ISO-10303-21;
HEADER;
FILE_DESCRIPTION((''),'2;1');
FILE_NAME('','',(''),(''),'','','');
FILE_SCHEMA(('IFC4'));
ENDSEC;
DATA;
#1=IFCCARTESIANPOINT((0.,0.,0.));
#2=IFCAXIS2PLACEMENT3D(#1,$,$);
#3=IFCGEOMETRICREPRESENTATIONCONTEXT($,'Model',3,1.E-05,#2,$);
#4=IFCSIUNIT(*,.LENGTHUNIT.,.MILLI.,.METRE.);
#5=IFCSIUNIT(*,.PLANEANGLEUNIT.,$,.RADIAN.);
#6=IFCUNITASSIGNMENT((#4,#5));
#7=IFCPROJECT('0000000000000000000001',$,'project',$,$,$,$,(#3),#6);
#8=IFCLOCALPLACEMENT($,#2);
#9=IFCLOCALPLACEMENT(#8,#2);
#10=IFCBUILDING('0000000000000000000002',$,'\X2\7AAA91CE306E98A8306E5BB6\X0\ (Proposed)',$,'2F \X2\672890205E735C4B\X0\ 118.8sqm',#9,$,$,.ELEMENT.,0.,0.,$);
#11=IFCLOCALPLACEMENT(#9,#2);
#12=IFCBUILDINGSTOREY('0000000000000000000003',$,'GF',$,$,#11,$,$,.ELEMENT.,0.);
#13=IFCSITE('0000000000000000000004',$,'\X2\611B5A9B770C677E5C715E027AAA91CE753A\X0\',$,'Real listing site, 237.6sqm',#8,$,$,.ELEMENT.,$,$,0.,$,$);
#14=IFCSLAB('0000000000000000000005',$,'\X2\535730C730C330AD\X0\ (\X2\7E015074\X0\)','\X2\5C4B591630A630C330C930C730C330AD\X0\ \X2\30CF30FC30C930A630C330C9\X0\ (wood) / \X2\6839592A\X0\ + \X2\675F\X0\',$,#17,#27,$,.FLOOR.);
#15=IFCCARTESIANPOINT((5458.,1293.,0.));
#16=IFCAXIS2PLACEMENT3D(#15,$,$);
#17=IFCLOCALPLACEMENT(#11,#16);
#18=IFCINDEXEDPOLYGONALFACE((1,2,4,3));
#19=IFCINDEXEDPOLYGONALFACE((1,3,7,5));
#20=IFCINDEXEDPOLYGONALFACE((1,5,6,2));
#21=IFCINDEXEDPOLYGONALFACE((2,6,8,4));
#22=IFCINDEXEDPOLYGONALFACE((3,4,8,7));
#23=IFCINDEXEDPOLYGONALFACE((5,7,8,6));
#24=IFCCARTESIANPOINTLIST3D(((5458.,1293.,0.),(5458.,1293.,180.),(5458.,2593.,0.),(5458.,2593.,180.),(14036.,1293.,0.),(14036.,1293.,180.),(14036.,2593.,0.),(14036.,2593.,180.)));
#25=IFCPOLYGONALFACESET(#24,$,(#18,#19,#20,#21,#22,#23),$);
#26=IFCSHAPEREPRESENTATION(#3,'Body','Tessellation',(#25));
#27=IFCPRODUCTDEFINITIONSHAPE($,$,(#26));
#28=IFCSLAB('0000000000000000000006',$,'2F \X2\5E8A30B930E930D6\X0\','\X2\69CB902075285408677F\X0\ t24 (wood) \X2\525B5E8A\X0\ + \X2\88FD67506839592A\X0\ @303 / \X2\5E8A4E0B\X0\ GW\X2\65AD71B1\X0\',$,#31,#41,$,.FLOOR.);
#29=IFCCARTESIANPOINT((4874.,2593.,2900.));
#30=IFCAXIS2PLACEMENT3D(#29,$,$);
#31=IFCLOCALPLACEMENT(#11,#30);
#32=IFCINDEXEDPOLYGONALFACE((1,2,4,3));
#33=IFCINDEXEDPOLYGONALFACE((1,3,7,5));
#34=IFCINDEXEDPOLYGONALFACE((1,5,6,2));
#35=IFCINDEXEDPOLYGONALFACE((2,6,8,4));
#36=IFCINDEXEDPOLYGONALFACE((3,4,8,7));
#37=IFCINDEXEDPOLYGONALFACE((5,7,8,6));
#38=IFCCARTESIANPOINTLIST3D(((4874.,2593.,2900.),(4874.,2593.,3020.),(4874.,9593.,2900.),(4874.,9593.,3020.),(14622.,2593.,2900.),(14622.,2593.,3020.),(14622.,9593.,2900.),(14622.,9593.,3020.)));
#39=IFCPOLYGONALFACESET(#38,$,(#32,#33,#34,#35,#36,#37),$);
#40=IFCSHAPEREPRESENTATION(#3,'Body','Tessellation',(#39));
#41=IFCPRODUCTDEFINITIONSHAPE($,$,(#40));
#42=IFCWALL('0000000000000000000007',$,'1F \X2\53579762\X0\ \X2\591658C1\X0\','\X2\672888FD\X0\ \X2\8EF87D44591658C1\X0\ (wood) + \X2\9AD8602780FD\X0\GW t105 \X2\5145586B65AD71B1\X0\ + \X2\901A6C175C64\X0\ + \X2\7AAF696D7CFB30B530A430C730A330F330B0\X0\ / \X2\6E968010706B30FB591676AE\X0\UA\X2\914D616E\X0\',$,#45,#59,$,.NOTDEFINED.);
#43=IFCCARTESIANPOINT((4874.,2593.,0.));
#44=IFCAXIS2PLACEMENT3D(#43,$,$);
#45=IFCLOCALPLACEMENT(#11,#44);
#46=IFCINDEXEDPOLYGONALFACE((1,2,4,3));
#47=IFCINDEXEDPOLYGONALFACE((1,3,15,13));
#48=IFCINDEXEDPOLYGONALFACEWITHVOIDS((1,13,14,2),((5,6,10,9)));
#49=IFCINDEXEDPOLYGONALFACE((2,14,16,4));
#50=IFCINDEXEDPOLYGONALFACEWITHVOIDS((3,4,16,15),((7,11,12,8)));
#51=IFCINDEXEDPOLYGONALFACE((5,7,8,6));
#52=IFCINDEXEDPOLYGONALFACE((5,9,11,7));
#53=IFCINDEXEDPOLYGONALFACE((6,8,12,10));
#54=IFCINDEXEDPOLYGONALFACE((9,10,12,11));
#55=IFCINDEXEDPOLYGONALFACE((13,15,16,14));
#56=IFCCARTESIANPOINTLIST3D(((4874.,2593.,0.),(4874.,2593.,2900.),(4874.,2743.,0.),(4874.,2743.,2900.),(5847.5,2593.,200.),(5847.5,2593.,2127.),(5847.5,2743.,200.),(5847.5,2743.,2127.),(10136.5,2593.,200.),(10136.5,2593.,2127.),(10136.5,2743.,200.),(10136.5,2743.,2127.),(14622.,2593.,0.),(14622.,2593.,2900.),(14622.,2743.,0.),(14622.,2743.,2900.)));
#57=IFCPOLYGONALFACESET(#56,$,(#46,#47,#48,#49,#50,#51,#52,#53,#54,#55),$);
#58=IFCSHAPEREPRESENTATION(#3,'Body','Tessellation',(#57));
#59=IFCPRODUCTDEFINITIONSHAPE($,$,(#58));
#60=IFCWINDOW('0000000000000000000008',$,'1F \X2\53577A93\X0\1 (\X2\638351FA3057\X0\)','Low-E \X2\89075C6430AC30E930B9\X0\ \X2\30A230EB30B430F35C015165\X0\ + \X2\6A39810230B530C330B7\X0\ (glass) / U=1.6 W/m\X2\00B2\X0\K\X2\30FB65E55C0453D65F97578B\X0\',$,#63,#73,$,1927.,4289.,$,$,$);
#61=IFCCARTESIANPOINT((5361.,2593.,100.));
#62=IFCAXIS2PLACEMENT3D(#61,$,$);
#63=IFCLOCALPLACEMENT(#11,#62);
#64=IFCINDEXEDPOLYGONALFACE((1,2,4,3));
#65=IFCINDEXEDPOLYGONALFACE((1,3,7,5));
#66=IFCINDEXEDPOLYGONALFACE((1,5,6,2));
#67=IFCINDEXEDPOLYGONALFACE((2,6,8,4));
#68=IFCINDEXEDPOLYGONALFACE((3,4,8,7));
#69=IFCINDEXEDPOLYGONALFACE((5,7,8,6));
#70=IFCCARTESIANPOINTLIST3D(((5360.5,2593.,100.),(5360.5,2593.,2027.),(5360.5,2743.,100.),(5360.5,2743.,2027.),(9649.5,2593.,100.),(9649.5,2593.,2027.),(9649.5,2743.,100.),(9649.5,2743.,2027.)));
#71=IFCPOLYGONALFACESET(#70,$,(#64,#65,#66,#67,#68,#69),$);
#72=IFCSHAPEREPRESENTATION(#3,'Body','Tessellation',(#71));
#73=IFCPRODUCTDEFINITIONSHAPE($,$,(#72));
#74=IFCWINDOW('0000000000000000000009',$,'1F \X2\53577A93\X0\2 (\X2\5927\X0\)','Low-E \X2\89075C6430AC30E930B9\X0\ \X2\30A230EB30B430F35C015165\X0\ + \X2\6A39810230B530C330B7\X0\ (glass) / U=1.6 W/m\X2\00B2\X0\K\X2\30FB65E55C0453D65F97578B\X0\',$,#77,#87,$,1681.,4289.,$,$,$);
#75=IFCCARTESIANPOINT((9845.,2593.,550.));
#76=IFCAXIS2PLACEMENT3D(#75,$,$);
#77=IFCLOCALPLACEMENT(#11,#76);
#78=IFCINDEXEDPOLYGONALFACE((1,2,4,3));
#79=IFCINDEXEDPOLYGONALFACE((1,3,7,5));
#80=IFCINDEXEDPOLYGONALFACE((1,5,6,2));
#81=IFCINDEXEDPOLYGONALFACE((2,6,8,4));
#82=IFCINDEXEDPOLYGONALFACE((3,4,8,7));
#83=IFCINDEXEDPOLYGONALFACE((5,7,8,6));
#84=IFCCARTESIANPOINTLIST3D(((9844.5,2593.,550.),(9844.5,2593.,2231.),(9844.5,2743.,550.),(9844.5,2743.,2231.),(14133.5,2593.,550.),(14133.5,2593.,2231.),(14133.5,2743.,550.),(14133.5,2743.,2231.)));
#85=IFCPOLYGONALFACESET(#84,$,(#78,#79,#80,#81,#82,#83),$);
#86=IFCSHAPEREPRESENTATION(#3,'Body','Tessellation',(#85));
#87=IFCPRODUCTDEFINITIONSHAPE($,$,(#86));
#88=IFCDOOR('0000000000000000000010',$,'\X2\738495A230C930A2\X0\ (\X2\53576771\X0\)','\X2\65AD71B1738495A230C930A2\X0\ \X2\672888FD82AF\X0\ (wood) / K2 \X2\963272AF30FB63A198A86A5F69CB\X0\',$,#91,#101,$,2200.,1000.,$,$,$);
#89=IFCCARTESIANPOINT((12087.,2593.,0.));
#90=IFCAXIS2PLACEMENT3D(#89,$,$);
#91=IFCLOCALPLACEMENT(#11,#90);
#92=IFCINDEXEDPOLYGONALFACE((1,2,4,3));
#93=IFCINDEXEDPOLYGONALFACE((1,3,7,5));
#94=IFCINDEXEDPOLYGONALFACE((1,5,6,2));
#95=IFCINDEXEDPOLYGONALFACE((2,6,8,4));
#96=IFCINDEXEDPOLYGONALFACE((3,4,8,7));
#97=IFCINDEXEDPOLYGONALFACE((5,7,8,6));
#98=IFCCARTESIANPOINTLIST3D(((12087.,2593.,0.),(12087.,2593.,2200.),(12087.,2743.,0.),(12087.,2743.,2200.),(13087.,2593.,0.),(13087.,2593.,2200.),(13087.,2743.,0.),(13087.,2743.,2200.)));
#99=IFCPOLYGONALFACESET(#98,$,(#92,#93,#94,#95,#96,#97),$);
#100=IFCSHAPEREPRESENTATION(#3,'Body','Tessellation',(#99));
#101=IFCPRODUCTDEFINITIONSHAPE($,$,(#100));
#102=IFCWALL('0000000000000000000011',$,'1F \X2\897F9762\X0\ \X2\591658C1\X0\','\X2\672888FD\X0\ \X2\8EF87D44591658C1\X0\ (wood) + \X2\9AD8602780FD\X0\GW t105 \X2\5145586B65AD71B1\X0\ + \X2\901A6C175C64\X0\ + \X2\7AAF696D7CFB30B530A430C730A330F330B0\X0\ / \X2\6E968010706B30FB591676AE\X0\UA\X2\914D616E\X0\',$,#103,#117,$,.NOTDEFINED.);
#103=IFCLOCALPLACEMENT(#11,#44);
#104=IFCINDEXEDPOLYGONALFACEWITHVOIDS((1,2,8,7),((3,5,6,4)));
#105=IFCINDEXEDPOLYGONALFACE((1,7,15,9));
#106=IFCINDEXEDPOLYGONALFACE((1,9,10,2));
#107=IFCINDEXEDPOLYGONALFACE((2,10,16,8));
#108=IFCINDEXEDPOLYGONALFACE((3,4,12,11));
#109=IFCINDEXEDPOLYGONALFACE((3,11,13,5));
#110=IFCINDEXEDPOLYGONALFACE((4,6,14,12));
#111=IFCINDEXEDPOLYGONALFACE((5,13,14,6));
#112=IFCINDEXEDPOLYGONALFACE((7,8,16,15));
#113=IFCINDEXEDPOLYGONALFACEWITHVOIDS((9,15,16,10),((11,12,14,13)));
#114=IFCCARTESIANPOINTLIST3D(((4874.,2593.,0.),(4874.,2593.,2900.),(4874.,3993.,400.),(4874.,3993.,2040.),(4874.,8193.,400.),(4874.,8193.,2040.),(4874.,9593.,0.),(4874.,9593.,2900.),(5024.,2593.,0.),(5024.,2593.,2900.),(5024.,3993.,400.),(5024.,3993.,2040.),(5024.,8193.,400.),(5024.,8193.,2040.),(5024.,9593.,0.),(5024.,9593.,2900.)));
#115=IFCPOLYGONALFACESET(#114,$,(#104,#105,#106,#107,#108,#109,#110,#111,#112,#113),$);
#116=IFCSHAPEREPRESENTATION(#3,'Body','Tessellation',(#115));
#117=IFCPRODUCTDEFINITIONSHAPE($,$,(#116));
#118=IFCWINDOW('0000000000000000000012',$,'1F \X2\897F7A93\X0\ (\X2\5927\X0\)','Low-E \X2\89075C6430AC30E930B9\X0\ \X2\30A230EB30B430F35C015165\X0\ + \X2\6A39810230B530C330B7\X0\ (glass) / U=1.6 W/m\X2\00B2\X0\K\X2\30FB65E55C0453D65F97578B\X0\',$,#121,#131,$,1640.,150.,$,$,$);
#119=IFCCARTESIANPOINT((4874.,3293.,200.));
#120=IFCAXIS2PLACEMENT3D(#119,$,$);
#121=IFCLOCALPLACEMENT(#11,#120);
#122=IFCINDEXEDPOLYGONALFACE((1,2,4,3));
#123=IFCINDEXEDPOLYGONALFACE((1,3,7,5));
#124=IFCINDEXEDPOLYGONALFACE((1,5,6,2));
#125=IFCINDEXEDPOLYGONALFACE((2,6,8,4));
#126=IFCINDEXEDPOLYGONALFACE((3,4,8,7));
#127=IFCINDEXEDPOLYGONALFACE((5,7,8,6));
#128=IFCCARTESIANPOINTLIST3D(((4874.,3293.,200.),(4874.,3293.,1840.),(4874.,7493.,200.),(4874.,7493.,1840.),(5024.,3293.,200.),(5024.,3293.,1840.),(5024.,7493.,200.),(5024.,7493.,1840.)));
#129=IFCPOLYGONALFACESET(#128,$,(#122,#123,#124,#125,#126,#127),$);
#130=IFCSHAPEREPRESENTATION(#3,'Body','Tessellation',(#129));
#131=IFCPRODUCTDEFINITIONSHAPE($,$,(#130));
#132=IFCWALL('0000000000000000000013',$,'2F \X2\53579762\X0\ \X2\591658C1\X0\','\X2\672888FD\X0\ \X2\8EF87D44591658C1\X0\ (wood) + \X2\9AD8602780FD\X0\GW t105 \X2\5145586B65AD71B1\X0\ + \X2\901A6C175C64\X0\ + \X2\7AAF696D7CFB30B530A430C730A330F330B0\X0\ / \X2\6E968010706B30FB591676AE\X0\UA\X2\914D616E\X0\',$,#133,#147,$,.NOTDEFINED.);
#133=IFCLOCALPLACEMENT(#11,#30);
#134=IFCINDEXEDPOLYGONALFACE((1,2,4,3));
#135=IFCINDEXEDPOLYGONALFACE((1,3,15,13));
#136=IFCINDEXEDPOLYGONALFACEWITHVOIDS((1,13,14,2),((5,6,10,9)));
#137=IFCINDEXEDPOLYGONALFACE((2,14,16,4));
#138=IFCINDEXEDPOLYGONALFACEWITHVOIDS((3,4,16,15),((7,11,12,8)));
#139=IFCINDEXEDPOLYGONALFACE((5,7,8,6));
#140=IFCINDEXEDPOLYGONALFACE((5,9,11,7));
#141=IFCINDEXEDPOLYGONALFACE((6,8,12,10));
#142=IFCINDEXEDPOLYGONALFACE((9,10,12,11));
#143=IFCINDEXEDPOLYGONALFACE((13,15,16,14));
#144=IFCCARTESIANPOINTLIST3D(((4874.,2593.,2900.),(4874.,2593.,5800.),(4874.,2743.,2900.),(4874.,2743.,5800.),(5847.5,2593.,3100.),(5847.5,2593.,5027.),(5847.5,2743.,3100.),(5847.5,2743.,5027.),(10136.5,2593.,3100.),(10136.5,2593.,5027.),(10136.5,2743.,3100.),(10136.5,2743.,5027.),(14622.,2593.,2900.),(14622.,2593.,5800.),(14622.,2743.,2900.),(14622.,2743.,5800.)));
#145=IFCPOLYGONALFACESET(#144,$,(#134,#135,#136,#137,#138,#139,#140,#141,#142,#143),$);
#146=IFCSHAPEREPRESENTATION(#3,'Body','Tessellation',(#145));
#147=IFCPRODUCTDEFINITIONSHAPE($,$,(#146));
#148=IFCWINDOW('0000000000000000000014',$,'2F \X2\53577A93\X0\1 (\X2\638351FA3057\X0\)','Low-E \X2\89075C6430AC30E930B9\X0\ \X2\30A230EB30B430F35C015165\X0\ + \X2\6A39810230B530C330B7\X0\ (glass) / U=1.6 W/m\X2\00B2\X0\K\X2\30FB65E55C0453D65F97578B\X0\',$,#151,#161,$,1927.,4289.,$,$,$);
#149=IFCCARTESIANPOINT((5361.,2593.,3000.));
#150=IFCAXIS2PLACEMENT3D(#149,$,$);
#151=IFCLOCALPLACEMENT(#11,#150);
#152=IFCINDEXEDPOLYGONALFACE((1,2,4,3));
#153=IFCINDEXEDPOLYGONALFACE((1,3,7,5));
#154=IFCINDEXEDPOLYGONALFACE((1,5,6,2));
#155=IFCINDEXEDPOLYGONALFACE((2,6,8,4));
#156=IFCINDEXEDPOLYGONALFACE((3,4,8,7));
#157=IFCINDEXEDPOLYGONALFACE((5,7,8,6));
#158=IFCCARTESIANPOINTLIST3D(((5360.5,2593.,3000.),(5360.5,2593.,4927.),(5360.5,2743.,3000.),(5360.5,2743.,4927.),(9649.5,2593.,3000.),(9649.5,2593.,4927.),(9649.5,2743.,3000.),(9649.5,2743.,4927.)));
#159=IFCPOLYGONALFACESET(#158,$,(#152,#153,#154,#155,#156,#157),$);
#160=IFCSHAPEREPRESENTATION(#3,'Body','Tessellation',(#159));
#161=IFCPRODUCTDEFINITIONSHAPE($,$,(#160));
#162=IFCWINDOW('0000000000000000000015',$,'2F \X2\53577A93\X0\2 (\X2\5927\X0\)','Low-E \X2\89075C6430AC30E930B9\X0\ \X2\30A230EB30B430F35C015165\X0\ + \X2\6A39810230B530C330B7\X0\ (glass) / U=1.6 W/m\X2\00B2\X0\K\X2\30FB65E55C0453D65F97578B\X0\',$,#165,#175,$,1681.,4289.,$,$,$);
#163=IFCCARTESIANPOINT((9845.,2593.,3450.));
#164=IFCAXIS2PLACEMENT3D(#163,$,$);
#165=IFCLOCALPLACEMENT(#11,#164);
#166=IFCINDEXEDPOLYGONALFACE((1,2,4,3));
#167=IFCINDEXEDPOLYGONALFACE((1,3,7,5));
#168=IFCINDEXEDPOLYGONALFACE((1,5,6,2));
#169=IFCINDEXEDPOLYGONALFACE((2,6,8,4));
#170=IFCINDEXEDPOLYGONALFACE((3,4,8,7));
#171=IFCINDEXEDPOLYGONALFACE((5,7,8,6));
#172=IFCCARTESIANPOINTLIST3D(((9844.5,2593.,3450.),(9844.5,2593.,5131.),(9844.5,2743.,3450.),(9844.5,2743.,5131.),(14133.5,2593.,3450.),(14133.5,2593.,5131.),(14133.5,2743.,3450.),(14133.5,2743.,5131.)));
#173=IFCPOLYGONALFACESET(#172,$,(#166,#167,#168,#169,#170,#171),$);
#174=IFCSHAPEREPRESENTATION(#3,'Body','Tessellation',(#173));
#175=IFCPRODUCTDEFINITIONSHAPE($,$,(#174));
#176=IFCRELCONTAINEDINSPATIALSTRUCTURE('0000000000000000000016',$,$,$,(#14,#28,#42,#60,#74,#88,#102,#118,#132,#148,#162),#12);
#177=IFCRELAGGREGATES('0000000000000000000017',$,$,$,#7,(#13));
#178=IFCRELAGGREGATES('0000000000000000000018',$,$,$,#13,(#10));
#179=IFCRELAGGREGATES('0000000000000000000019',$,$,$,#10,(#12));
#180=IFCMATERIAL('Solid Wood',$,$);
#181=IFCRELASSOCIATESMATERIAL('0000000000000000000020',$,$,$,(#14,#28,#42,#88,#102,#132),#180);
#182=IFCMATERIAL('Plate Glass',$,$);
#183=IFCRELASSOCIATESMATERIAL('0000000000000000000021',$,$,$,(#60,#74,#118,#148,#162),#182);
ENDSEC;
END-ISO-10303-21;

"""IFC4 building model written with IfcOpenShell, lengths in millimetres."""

from ifc_helpers import new_model, si_unit, frame, frame_2d, origin, place, context, project, spatial, rectangle, extrude, material, element, fill, save


model = new_model("IFC4")

# Units and contexts
model_context = context("Model", 3, precision=1e-05, world=origin())
ifc_project = project(units=[si_unit("LENGTHUNIT", "METRE", prefix="MILLI"), si_unit("PLANEANGLEUNIT", "RADIAN")], contexts=[model_context])

# Site, building, storey
site_placement = place(None, origin())
site = spatial("IfcSite", under=ifc_project, at=site_placement, Name="愛媛県松山市窪野町", ObjectType="Real listing site, 237.6sqm", CompositionType="ELEMENT", RefElevation=0.0)
building_placement = place(site_placement, origin())
building = spatial("IfcBuilding", under=site, at=building_placement, Name="窪野の風の家 (Proposed)", ObjectType="2F 木造平屋 118.8sqm", CompositionType="ELEMENT", ElevationOfRefHeight=0.0, ElevationOfTerrain=0.0)
storey_placement = place(building_placement, origin())
storey = spatial("IfcBuildingStorey", under=building, at=storey_placement, Name="GF", CompositionType="ELEMENT", Elevation=0.0)

# Slabs
ifc_material_1 = material(Name="Solid Wood")
slab_1_placement = place(storey_placement, frame((5458.0, 1293.0, 0.0)))
element("IfcSlab", 1, at=slab_1_placement, inside=storey, material=ifc_material_1, Name="南デッキ (縁側)", Description="屋外ウッドデッキ ハードウッド (wood) / 根太 + 束", PredefinedType="FLOOR", context=model_context, shape_type="SweptSolid", body=[
    extrude(rectangle(XDim=8578.0, YDim=1300.0, at=frame_2d((4289.0, 650.0))), frame((5458.0, 1293.0, 0.0)), (0.0, 0.0, 1.0), 180.0),
])
slab_2_placement = place(storey_placement, frame((4874.0, 2593.0, 2900.0)))
element("IfcSlab", 2, at=slab_2_placement, inside=storey, material=ifc_material_1, Name="2F 床スラブ", Description="構造用合板 t24 (wood) 剛床 + 製材根太 @303 / 床下 GW断熱", PredefinedType="FLOOR", context=model_context, shape_type="SweptSolid", body=[
    extrude(rectangle(XDim=9748.0, YDim=7000.0, at=frame_2d((4874.0, 3500.0))), frame((4874.0, 2593.0, 2900.0)), (0.0, 0.0, 1.0), 120.0),
])

# Wall, openings, windows, door
wall_1_placement = place(storey_placement, frame((4874.0, 2593.0, 0.0)))
wall_1 = element("IfcWall", 3, at=wall_1_placement, inside=storey, material=ifc_material_1, Name="1F 南面 外壁", Description="木製 軸組外壁 (wood) + 高性能GW t105 充填断熱 + 通気層 + 窯業系サイディング / 準耐火・外皮UA配慮", PredefinedType="NOTDEFINED", context=model_context, shape_type="SweptSolid", body=[
    extrude(rectangle(XDim=9748.0, YDim=150.0, at=frame_2d((4874.0, 75.0))), frame((4874.0, 2593.0, 0.0)), (0.0, 0.0, 1.0), 2900.0),
])
opening_1_placement = place(storey_placement, frame((5361.0, 2593.0, 100.0)))
opening_1 = element("IfcOpeningElement", 4, at=opening_1_placement, cuts=wall_1, PredefinedType="NOTDEFINED", context=model_context, shape_type="SweptSolid", body=[
    extrude(rectangle(XDim=4289.0, YDim=150.0, at=frame_2d((2144.0, 75.0))), frame((5361.0, 2593.0, 100.0)), (0.0, 0.0, 1.0), 1927.0),
])
opening_2_placement = place(storey_placement, frame((9845.0, 2593.0, 550.0)))
opening_2 = element("IfcOpeningElement", 5, at=opening_2_placement, cuts=wall_1, PredefinedType="NOTDEFINED", context=model_context, shape_type="SweptSolid", body=[
    extrude(rectangle(XDim=4289.0, YDim=150.0, at=frame_2d((2144.0, 75.0))), frame((9845.0, 2593.0, 550.0)), (0.0, 0.0, 1.0), 1681.0),
])
opening_3_placement = place(storey_placement, frame((12087.0, 2593.0, 0.0)))
opening_3 = element("IfcOpeningElement", 6, at=opening_3_placement, cuts=wall_1, PredefinedType="NOTDEFINED", context=model_context, shape_type="SweptSolid", body=[
    extrude(rectangle(XDim=1000.0, YDim=150.0, at=frame_2d((500.0, 75.0))), frame((12087.0, 2593.0, 0.0)), (0.0, 0.0, 1.0), 2200.0),
])
ifc_material_2 = material(Name="Plate Glass")
window_1_placement = place(storey_placement, frame((5361.0, 2593.0, 100.0)))
window_1 = element("IfcWindow", 7, at=window_1_placement, inside=storey, material=ifc_material_2, Name="1F 南窓1 (掃出し)", Description="Low-E 複層ガラス アルゴン封入 + 樹脂サッシ (glass) / U=1.6 W/m²K・日射取得型", OverallHeight=1927.0, OverallWidth=4289.0, context=model_context, shape_type="SweptSolid", body=[
    extrude(rectangle(XDim=4289.0, YDim=150.0, at=frame_2d((2144.0, 75.0))), frame((5361.0, 2593.0, 100.0)), (0.0, 0.0, 1.0), 1927.0),
])
fill(opening_1, window_1)
window_2_placement = place(storey_placement, frame((9845.0, 2593.0, 550.0)))
window_2 = element("IfcWindow", 8, at=window_2_placement, inside=storey, material=ifc_material_2, Name="1F 南窓2 (大)", Description="Low-E 複層ガラス アルゴン封入 + 樹脂サッシ (glass) / U=1.6 W/m²K・日射取得型", OverallHeight=1681.0, OverallWidth=4289.0, context=model_context, shape_type="SweptSolid", body=[
    extrude(rectangle(XDim=4289.0, YDim=150.0, at=frame_2d((2144.0, 75.0))), frame((9845.0, 2593.0, 550.0)), (0.0, 0.0, 1.0), 1681.0),
])
fill(opening_2, window_2)
door_placement = place(storey_placement, frame((12087.0, 2593.0, 0.0)))
door = element("IfcDoor", 9, at=door_placement, inside=storey, material=ifc_material_1, Name="玄関ドア (南東)", Description="断熱玄関ドア 木製芯 (wood) / K2 防犯・採風機構", OverallHeight=2200.0, OverallWidth=1000.0, context=model_context, shape_type="SweptSolid", body=[
    extrude(rectangle(XDim=1000.0, YDim=150.0, at=frame_2d((500.0, 75.0))), frame((12087.0, 2593.0, 0.0)), (0.0, 0.0, 1.0), 2200.0),
])
fill(opening_3, door)

# Wall, opening, window
wall_2_placement = place(storey_placement, frame((4874.0, 2593.0, 0.0)))
wall_2 = element("IfcWall", 10, at=wall_2_placement, inside=storey, material=ifc_material_1, Name="1F 西面 外壁", Description="木製 軸組外壁 (wood) + 高性能GW t105 充填断熱 + 通気層 + 窯業系サイディング / 準耐火・外皮UA配慮", PredefinedType="NOTDEFINED", context=model_context, shape_type="SweptSolid", body=[
    extrude(rectangle(XDim=150.0, YDim=7000.0, at=frame_2d((75.0, 3500.0))), frame((4874.0, 2593.0, 0.0)), (0.0, 0.0, 1.0), 2900.0),
])
opening_4_placement = place(storey_placement, frame((4874.0, 3293.0, 200.0)))
opening_4 = element("IfcOpeningElement", 11, at=opening_4_placement, cuts=wall_2, PredefinedType="NOTDEFINED", context=model_context, shape_type="SweptSolid", body=[
    extrude(rectangle(XDim=150.0, YDim=4200.0, at=frame_2d((75.0, 2100.0))), frame((4874.0, 3293.0, 200.0)), (0.0, 0.0, 1.0), 1640.0),
])
window_3_placement = place(storey_placement, frame((4874.0, 3293.0, 200.0)))
window_3 = element("IfcWindow", 12, at=window_3_placement, inside=storey, material=ifc_material_2, Name="1F 西窓 (大)", Description="Low-E 複層ガラス アルゴン封入 + 樹脂サッシ (glass) / U=1.6 W/m²K・日射取得型", OverallHeight=1640.0, OverallWidth=150.0, context=model_context, shape_type="SweptSolid", body=[
    extrude(rectangle(XDim=150.0, YDim=4200.0, at=frame_2d((75.0, 2100.0))), frame((4874.0, 3293.0, 200.0)), (0.0, 0.0, 1.0), 1640.0),
])
fill(opening_4, window_3)

# Wall, openings, windows
wall_3_placement = place(storey_placement, frame((4874.0, 2593.0, 2900.0)))
wall_3 = element("IfcWall", 13, at=wall_3_placement, inside=storey, material=ifc_material_1, Name="2F 南面 外壁", Description="木製 軸組外壁 (wood) + 高性能GW t105 充填断熱 + 通気層 + 窯業系サイディング / 準耐火・外皮UA配慮", PredefinedType="NOTDEFINED", context=model_context, shape_type="SweptSolid", body=[
    extrude(rectangle(XDim=9748.0, YDim=150.0, at=frame_2d((4874.0, 75.0))), frame((4874.0, 2593.0, 2900.0)), (0.0, 0.0, 1.0), 2900.0),
])
opening_5_placement = place(storey_placement, frame((5361.0, 2593.0, 3000.0)))
opening_5 = element("IfcOpeningElement", 14, at=opening_5_placement, cuts=wall_3, PredefinedType="NOTDEFINED", context=model_context, shape_type="SweptSolid", body=[
    extrude(rectangle(XDim=4289.0, YDim=150.0, at=frame_2d((2144.0, 75.0))), frame((5361.0, 2593.0, 3000.0)), (0.0, 0.0, 1.0), 1927.0),
])
opening_6_placement = place(storey_placement, frame((9845.0, 2593.0, 3450.0)))
opening_6 = element("IfcOpeningElement", 15, at=opening_6_placement, cuts=wall_3, PredefinedType="NOTDEFINED", context=model_context, shape_type="SweptSolid", body=[
    extrude(rectangle(XDim=4289.0, YDim=150.0, at=frame_2d((2144.0, 75.0))), frame((9845.0, 2593.0, 3450.0)), (0.0, 0.0, 1.0), 1681.0),
])
window_4_placement = place(storey_placement, frame((5361.0, 2593.0, 3000.0)))
window_4 = element("IfcWindow", 16, at=window_4_placement, inside=storey, material=ifc_material_2, Name="2F 南窓1 (掃出し)", Description="Low-E 複層ガラス アルゴン封入 + 樹脂サッシ (glass) / U=1.6 W/m²K・日射取得型", OverallHeight=1927.0, OverallWidth=4289.0, context=model_context, shape_type="SweptSolid", body=[
    extrude(rectangle(XDim=4289.0, YDim=150.0, at=frame_2d((2144.0, 75.0))), frame((5361.0, 2593.0, 3000.0)), (0.0, 0.0, 1.0), 1927.0),
])
fill(opening_5, window_4)
window_5_placement = place(storey_placement, frame((9845.0, 2593.0, 3450.0)))
window_5 = element("IfcWindow", 17, at=window_5_placement, inside=storey, material=ifc_material_2, Name="2F 南窓2 (大)", Description="Low-E 複層ガラス アルゴン封入 + 樹脂サッシ (glass) / U=1.6 W/m²K・日射取得型", OverallHeight=1681.0, OverallWidth=4289.0, context=model_context, shape_type="SweptSolid", body=[
    extrude(rectangle(XDim=4289.0, YDim=150.0, at=frame_2d((2144.0, 75.0))), frame((9845.0, 2593.0, 3450.0)), (0.0, 0.0, 1.0), 1681.0),
])
fill(opening_6, window_5)

save(model, "model.ifc")
